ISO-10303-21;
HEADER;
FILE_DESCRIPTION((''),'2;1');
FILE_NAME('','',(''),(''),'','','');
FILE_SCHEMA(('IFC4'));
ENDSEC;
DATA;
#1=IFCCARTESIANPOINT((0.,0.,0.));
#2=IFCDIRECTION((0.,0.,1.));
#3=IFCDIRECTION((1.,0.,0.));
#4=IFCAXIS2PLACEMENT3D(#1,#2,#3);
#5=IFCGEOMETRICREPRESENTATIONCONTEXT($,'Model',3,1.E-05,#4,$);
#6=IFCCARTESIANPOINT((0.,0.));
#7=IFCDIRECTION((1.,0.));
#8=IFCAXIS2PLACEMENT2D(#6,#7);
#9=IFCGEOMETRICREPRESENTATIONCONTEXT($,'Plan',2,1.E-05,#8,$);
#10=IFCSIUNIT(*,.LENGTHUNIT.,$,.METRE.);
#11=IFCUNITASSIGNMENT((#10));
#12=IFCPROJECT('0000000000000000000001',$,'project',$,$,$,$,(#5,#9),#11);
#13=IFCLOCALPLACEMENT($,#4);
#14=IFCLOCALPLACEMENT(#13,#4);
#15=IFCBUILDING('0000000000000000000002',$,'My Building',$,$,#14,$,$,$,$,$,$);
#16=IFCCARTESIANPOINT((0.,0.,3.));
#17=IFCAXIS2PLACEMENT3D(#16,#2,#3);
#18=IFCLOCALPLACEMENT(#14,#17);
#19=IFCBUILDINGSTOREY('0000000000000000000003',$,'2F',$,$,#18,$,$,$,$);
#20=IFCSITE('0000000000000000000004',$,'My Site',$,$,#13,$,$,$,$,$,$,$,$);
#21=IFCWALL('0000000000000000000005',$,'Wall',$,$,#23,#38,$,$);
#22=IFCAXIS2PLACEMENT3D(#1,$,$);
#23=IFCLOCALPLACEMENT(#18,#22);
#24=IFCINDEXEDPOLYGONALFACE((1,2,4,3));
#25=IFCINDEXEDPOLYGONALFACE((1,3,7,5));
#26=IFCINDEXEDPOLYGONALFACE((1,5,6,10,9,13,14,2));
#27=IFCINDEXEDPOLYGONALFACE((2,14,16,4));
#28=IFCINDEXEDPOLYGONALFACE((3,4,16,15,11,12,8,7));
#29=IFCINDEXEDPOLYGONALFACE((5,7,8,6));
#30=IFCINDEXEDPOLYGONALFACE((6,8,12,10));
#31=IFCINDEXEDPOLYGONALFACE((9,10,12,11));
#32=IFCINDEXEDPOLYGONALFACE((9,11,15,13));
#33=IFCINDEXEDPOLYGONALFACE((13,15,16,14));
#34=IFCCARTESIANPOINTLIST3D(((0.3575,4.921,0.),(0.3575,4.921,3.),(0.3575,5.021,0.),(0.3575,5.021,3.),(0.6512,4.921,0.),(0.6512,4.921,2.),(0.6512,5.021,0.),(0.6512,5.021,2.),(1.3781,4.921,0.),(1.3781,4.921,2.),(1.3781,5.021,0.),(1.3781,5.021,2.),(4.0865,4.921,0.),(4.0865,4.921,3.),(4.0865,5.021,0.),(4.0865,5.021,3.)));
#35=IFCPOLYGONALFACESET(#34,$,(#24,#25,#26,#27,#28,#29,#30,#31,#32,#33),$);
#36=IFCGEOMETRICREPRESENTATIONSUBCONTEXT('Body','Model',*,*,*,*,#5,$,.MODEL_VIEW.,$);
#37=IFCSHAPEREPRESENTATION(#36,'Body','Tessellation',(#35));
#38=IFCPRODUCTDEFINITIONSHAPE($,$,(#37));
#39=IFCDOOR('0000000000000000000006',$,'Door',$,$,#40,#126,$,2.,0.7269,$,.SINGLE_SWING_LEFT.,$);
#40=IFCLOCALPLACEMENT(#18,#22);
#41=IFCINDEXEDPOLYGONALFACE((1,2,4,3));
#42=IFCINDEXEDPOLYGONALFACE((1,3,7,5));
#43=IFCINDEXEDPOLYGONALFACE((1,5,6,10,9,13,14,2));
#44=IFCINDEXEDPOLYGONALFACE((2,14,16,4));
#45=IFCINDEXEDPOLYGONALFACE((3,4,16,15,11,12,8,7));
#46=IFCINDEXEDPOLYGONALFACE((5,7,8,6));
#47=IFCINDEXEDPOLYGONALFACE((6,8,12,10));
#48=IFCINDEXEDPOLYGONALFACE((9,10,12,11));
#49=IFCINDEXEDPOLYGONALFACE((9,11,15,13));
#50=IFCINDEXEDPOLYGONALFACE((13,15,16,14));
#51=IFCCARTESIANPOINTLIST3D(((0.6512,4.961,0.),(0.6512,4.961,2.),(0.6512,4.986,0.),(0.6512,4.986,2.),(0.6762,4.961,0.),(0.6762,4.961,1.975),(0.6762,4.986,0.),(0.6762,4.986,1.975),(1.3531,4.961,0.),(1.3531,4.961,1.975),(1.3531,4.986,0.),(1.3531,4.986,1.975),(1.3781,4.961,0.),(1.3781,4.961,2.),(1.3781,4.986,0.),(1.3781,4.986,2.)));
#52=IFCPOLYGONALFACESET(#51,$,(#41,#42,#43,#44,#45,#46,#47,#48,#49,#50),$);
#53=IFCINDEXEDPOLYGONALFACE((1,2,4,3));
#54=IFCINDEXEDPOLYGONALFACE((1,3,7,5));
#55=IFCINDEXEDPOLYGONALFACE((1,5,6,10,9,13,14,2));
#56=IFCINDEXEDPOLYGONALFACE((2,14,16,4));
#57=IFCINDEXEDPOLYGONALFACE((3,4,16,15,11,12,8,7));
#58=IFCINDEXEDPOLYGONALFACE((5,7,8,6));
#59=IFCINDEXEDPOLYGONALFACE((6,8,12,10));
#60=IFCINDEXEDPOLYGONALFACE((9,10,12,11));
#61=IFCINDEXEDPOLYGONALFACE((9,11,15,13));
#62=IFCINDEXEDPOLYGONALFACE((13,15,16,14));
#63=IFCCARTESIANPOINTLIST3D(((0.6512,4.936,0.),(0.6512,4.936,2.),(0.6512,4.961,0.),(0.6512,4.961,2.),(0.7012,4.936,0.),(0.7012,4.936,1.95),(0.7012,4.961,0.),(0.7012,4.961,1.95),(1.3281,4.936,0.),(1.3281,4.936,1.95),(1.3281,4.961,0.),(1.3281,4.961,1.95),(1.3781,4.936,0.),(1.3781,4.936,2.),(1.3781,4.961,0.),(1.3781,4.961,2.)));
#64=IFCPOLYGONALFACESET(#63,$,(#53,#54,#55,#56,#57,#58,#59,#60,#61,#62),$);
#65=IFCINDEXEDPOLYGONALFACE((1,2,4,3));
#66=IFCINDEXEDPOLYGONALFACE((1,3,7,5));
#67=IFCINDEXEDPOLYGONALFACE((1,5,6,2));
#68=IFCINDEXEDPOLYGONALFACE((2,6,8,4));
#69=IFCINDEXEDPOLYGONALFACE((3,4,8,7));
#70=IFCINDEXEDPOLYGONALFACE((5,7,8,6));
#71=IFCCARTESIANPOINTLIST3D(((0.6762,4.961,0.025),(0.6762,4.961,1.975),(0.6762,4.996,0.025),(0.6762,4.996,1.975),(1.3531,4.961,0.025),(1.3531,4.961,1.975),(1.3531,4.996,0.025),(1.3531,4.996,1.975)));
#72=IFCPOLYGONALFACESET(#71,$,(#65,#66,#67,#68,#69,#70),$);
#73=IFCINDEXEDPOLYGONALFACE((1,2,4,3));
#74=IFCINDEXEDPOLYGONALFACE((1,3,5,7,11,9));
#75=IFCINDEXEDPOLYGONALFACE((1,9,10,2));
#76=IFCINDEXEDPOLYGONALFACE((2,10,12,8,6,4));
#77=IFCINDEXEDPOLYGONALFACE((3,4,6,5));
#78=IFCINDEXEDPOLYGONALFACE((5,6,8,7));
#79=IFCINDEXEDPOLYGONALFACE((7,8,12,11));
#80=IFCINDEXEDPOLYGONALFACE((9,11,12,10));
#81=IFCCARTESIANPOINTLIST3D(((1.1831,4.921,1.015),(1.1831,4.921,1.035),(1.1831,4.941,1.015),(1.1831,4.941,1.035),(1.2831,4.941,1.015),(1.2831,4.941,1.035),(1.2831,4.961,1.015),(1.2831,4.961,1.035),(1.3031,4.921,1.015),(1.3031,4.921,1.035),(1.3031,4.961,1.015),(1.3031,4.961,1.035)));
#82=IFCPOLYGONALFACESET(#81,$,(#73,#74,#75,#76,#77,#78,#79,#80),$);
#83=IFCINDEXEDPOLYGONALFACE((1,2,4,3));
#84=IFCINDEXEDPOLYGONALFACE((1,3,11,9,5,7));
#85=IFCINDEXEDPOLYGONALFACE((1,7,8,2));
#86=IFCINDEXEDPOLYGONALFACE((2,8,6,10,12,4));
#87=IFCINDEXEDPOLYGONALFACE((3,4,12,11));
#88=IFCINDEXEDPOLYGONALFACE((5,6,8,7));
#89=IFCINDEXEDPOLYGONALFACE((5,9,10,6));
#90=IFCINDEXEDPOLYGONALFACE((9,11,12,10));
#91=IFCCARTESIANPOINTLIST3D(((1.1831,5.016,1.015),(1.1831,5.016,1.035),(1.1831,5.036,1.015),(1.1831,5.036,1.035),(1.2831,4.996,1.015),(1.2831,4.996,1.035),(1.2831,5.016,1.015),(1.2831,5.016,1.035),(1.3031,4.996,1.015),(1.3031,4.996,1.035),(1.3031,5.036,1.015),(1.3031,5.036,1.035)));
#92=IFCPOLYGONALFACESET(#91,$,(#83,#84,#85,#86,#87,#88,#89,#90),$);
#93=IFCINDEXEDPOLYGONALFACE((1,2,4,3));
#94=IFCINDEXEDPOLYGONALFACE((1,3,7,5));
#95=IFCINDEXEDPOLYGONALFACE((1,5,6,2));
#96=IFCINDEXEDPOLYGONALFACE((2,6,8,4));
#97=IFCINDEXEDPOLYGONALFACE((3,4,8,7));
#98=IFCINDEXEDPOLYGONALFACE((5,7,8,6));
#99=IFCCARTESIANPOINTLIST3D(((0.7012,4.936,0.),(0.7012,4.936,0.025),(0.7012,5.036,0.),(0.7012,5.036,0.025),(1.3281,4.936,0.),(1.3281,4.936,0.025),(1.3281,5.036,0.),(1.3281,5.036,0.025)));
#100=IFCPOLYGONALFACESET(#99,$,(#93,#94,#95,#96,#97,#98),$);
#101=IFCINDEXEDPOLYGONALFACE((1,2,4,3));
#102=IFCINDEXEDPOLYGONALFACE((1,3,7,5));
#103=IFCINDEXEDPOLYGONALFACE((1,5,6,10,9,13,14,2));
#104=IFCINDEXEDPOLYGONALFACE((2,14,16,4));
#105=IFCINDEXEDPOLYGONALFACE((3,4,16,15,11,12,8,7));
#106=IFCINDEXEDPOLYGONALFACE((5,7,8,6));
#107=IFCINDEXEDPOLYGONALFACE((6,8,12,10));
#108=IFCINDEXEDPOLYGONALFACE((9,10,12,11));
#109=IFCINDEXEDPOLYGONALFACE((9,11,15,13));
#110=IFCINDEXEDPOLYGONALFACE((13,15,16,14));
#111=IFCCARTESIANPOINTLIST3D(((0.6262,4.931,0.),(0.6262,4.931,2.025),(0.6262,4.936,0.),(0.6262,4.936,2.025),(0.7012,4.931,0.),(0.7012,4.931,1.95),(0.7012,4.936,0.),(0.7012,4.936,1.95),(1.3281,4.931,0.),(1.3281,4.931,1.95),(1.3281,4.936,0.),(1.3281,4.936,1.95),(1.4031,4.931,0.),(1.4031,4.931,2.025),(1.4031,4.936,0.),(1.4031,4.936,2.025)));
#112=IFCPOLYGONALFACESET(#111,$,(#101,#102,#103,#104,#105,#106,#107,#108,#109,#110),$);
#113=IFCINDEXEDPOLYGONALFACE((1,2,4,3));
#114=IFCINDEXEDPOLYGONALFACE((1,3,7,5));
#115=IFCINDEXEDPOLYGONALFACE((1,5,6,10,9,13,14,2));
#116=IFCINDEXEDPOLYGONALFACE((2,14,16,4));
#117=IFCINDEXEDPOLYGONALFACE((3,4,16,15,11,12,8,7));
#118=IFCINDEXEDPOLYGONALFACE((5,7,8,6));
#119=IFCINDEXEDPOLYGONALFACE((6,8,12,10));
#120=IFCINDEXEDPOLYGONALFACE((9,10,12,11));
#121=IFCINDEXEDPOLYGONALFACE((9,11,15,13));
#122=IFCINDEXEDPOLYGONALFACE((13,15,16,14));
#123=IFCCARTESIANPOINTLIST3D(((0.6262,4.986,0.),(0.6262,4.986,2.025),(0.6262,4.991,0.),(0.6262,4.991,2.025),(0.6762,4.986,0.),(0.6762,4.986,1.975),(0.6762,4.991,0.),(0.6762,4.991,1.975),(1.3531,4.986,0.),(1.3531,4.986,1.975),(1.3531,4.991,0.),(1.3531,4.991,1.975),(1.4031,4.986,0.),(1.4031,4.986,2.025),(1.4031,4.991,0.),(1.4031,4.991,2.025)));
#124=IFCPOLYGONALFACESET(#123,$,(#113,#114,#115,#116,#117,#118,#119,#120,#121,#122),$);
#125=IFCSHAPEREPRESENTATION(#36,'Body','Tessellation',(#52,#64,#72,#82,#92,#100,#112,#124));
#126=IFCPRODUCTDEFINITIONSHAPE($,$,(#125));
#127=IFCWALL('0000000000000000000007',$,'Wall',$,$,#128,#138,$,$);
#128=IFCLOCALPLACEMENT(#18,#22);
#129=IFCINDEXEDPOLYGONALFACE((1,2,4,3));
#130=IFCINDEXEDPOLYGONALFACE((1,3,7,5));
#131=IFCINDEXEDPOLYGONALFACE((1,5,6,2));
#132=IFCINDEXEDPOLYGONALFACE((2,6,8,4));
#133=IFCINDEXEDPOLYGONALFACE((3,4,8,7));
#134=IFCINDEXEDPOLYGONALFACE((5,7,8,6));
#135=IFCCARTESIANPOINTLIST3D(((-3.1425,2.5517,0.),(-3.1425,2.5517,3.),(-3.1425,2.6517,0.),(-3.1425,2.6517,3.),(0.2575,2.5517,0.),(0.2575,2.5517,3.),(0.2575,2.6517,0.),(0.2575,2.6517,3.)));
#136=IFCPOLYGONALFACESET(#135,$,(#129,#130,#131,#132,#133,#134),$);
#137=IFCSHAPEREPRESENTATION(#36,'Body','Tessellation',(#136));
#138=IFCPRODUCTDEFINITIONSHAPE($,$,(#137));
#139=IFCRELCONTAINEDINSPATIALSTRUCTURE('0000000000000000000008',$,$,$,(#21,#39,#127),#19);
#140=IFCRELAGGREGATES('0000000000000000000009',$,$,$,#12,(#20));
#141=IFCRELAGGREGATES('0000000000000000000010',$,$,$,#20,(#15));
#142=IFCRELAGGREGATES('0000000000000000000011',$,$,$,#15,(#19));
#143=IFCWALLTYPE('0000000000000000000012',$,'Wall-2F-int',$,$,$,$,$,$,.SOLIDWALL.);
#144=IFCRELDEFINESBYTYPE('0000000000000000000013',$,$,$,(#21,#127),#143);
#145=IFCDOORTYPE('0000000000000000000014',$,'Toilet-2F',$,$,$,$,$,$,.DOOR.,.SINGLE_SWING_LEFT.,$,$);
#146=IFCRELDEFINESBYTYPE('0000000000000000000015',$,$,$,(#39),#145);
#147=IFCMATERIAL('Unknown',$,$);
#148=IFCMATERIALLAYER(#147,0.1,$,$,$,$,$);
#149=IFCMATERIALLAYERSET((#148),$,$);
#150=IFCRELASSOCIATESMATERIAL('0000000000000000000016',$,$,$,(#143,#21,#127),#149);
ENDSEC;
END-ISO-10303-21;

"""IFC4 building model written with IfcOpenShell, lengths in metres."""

from ifc_helpers import new_model, entity, si_unit, frame, origin_with_axes, origin_2d_with_axis, place, context, subcontext, project, spatial, line, indexed_curve, outline, extrude, shape, source, transform, mapped, material, layer, layer_set, layer_usage, type_object, type_shapes, element, fill, save


model = new_model("IFC4")

# Units and contexts
model_context = context("Model", 3, precision=1e-05, world=origin_with_axes())
plan_context = context("Plan", 2, precision=1e-05, world=origin_2d_with_axis())
body_context_1 = subcontext(model_context, "Body", "Model", "MODEL_VIEW")
body_context_2 = subcontext(plan_context, "Body", "Plan", "PLAN_VIEW")
ifc_project = project(units=[si_unit("LENGTHUNIT", "METRE")], contexts=[model_context, plan_context])

# Site, building, storey
site_placement = place(None, origin_with_axes())
site = spatial("IfcSite", under=ifc_project, at=site_placement, Name="My Site")
building_placement = place(site_placement, origin_with_axes())
building = spatial("IfcBuilding", under=site, at=building_placement, Name="My Building")
storey_placement = place(building_placement, frame((0.0, 0.0, 3.0), z_axis=(0.0, 0.0, 1.0), x_axis=(1.0, 0.0, 0.0)))
storey = spatial("IfcBuildingStorey", under=building, at=storey_placement, Name="2F")

# Shared definitions
ifc_material = material(Name="Unknown")

# Shared definitions
ifc_layer_1 = layer(ifc_material, 0.1)
ifc_layer_set_1 = layer_set([ifc_layer_1])
wall_type_1 = type_object("IfcWallType", Name="Wall-2F-int", PredefinedType="SOLIDWALL", material=ifc_layer_set_1)

# Wall, opening, door
ifc_layer_usage_1 = layer_usage(ifc_layer_set_1, "AXIS2", "POSITIVE", 0.0)
wall_1_placement = place(storey_placement, frame((0.3575, 4.921, 0.0), z_axis=(0.0, 0.0, 1.0), x_axis=(1.0, 0.0, 0.0)))
wall_1 = element("IfcWall", 1, at=wall_1_placement, inside=storey, type_object=wall_type_1, material=ifc_layer_usage_1, Name="Wall", context=body_context_1, shape_type="SweptSolid", body=[
    extrude(outline(indexed_curve([(0.0, 0.0), (0.0, 0.1), (3.729, 0.1), (3.729, 0.0)], segments=[line(1, 2, 3, 4, 1)])), origin_with_axes(), (0.0, 0.0, 1.0), 3.0),
])
shared_shape_1 = source(origin_with_axes(), body_context_1, "Body", "SweptSolid", [
    extrude(outline(indexed_curve([(0.0, 0.0), (0.7269, 0.0), (0.7269, 2.0), (0.0, 2.0)], segments=[line(1, 2, 3, 4, 1)])), frame((0.0, -0.6, 0.0), z_axis=(0.0, -1.0, 0.0), x_axis=(1.0, 0.0, 0.0)), (0.0, 0.0, -1.0), 1.2),
])
opening_1_placement = place(wall_1_placement, frame((0.2937, 0.015, 0.0), z_axis=(0.0, 0.0, 1.0), x_axis=(1.0, 0.0, 0.0)))
opening_1 = element("IfcOpeningElement", 2, at=opening_1_placement, cuts=wall_1, PredefinedType="OPENING", context=body_context_1, shape_type="MappedRepresentation", body=[
    mapped(shared_shape_1, transform((0.0, 0.0, 0.0), x_axis=(1.0, 0.0, 0.0), y_axis=(0.0, 1.0, 0.0), z_axis=(0.0, 0.0, 1.0), scale=1.0)),
])
door_type_1 = type_object("IfcDoorType", Name="Toilet-2F", OperationType="SINGLE_SWING_LEFT", PredefinedType="DOOR")
shared_shape_2 = source(origin_with_axes(), body_context_1, "Body", "SweptSolid", [
    extrude(outline(indexed_curve([(0.0, 0.0), (0.0, 2.0), (0.7269, 2.0), (0.7269, 0.0), (0.7019, 0.0), (0.7019, 1.975), (0.025, 1.975), (0.025, 0.0)], segments=[line(1, 2, 3, 4, 5, 6, 7, 8, 1)])), frame((0.0, 0.025, 0.0), z_axis=(0.0, -1.0, 0.0), x_axis=(1.0, 0.0, 0.0)), (0.0, 0.0, -1.0), 0.025),
    extrude(outline(indexed_curve([(0.0, 0.0), (0.0, 2.0), (0.7269, 2.0), (0.7269, 0.0), (0.6769, 0.0), (0.6769, 1.95), (0.05, 1.95), (0.05, 0.0)], segments=[line(1, 2, 3, 4, 5, 6, 7, 8, 1)])), frame((0.0, 0.0, 0.0), z_axis=(0.0, -1.0, 0.0), x_axis=(1.0, 0.0, 0.0)), (0.0, 0.0, -1.0), 0.025),
    extrude(outline(indexed_curve([(0.0, 0.0), (0.6769, 0.0), (0.6769, 0.035), (0.0, 0.035)], segments=[line(1, 2, 3, 4, 1)])), frame((0.025, 0.025, 0.025), z_axis=(0.0, 0.0, 1.0), x_axis=(1.0, 0.0, 0.0)), (0.0, 0.0, 1.0), 1.95),
    extrude(outline(indexed_curve([(0.0, 0.0), (0.0, -0.04), (-0.12, -0.04), (-0.12, -0.02), (-0.02, -0.02), (-0.02, 0.0)], segments=[line(1, 2, 3, 4, 5, 6, 1)])), frame((0.6519, 0.025, 1.015), z_axis=(0.0, 0.0, 1.0), x_axis=(1.0, 0.0, 0.0)), (0.0, 0.0, 1.0), 0.02),
    extrude(outline(indexed_curve([(0.0, 0.0), (0.0, 0.04), (-0.12, 0.04), (-0.12, 0.02), (-0.02, 0.02), (-0.02, 0.0)], segments=[line(1, 2, 3, 4, 5, 6, 1)])), frame((0.6519, 0.06, 1.015), z_axis=(0.0, 0.0, 1.0), x_axis=(1.0, 0.0, 0.0)), (0.0, 0.0, 1.0), 0.02),
    extrude(outline(indexed_curve([(0.0, 0.0), (0.6269, 0.0), (0.6269, 0.1), (0.0, 0.1)], segments=[line(1, 2, 3, 4, 1)])), frame((0.05, 0.0, 0.0), z_axis=(0.0, 0.0, 1.0), x_axis=(1.0, 0.0, 0.0)), (0.0, 0.0, 1.0), 0.025),
    extrude(outline(indexed_curve([(0.0, 0.0), (0.0, 2.025), (0.7769, 2.025), (0.7769, 0.0), (0.7019, 0.0), (0.7019, 1.95), (0.075, 1.95), (0.075, 0.0)], segments=[line(1, 2, 3, 4, 5, 6, 7, 8, 1)])), frame((-0.025, -0.005, 0.0), z_axis=(0.0, -1.0, 0.0), x_axis=(1.0, 0.0, 0.0)), (0.0, 0.0, -1.0), 0.005),
    extrude(outline(indexed_curve([(0.0, 0.0), (0.0, 2.025), (0.7769, 2.025), (0.7769, 0.0), (0.7269, 0.0), (0.7269, 1.975), (0.05, 1.975), (0.05, 0.0)], segments=[line(1, 2, 3, 4, 5, 6, 7, 8, 1)])), frame((-0.025, 0.05, 0.0), z_axis=(0.0, -1.0, 0.0), x_axis=(1.0, 0.0, 0.0)), (0.0, 0.0, -1.0), 0.005),
])
shared_shape_3 = source(origin_with_axes(), body_context_2, "Body", "Curve2D", [
    entity("IfcIndexedPolyCurve", entity("IfcCartesianPointList2D", [[0.0, 0.0], [0.0, 0.05], [0.025, 0.05], [0.025, 0.025], [0.05, 0.025], [0.05, 0.0]]), [entity("IfcLineIndex", [1, 2, 3, 4, 5, 6, 1])]),
    entity("IfcIndexedPolyCurve", entity("IfcCartesianPointList2D", [[0.7269, 0.0], [0.7269, 0.05], [0.7019, 0.05], [0.7019, 0.025], [0.6769, 0.025], [0.6769, 0.0]]), [entity("IfcLineIndex", [1, 2, 3, 4, 5, 6, 1])]),
    entity("IfcTrimmedCurve", entity("IfcEllipse", entity("IfcAxis2Placement2D", entity("IfcCartesianPoint", [0.06, 0.05]), entity("IfcDirection", [1.0, 0.0])), 0.6419, 0.6769), [entity("IfcCartesianPoint", [0.7019, 0.05])], [entity("IfcCartesianPoint", [0.06, 0.7269])], True, "CARTESIAN"),
    entity("IfcIndexedPolyCurve", entity("IfcCartesianPointList2D", [[0.025, 0.05], [0.06, 0.05], [0.06, 0.7269], [0.025, 0.7269]]), [entity("IfcLineIndex", [1, 2, 3, 4, 1])]),
])
type_shapes(door_type_1, [shared_shape_2, shared_shape_3])
door_1_placement = place(opening_1_placement, frame((0.0, 0.0, 0.0), z_axis=(0.0, 0.0, 1.0), x_axis=(1.0, 0.0, 0.0)))
door_1 = element("IfcDoor", 3, at=door_1_placement, inside=storey, type_object=door_type_1, Name="Door", OperationType="SINGLE_SWING_LEFT", OverallHeight=2.0, OverallWidth=0.7269, shapes=[
    shape(body_context_1, "Body", "MappedRepresentation", [mapped(shared_shape_2, transform((0.0, 0.0, 0.0), x_axis=(1.0, 0.0, 0.0), y_axis=(0.0, 1.0, 0.0), z_axis=(0.0, 0.0, 1.0), scale=1.0))]),
    shape(body_context_2, "Body", "MappedRepresentation", [mapped(shared_shape_3, transform((0.0, 0.0, 0.0), x_axis=(1.0, 0.0, 0.0), y_axis=(0.0, 1.0, 0.0), z_axis=(0.0, 0.0, 1.0), scale=1.0))]),
])
fill(opening_1, door_1)

# Wall
ifc_layer_usage_2 = layer_usage(ifc_layer_set_1, "AXIS2", "POSITIVE", 0.0)
wall_2_placement = place(storey_placement, frame((-3.1425, 2.5517, 0.0), z_axis=(0.0, 0.0, 1.0), x_axis=(1.0, 0.0, 0.0)))
element("IfcWall", 4, at=wall_2_placement, inside=storey, type_object=wall_type_1, material=ifc_layer_usage_2, Name="Wall", context=body_context_1, shape_type="SweptSolid", body=[
    extrude(outline(indexed_curve([(0.0, 0.0), (0.0, 0.1), (3.4, 0.1), (3.4, 0.0)], segments=[line(1, 2, 3, 4, 1)])), origin_with_axes(), (0.0, 0.0, 1.0), 3.0),
])

save(model, "model.ifc")
